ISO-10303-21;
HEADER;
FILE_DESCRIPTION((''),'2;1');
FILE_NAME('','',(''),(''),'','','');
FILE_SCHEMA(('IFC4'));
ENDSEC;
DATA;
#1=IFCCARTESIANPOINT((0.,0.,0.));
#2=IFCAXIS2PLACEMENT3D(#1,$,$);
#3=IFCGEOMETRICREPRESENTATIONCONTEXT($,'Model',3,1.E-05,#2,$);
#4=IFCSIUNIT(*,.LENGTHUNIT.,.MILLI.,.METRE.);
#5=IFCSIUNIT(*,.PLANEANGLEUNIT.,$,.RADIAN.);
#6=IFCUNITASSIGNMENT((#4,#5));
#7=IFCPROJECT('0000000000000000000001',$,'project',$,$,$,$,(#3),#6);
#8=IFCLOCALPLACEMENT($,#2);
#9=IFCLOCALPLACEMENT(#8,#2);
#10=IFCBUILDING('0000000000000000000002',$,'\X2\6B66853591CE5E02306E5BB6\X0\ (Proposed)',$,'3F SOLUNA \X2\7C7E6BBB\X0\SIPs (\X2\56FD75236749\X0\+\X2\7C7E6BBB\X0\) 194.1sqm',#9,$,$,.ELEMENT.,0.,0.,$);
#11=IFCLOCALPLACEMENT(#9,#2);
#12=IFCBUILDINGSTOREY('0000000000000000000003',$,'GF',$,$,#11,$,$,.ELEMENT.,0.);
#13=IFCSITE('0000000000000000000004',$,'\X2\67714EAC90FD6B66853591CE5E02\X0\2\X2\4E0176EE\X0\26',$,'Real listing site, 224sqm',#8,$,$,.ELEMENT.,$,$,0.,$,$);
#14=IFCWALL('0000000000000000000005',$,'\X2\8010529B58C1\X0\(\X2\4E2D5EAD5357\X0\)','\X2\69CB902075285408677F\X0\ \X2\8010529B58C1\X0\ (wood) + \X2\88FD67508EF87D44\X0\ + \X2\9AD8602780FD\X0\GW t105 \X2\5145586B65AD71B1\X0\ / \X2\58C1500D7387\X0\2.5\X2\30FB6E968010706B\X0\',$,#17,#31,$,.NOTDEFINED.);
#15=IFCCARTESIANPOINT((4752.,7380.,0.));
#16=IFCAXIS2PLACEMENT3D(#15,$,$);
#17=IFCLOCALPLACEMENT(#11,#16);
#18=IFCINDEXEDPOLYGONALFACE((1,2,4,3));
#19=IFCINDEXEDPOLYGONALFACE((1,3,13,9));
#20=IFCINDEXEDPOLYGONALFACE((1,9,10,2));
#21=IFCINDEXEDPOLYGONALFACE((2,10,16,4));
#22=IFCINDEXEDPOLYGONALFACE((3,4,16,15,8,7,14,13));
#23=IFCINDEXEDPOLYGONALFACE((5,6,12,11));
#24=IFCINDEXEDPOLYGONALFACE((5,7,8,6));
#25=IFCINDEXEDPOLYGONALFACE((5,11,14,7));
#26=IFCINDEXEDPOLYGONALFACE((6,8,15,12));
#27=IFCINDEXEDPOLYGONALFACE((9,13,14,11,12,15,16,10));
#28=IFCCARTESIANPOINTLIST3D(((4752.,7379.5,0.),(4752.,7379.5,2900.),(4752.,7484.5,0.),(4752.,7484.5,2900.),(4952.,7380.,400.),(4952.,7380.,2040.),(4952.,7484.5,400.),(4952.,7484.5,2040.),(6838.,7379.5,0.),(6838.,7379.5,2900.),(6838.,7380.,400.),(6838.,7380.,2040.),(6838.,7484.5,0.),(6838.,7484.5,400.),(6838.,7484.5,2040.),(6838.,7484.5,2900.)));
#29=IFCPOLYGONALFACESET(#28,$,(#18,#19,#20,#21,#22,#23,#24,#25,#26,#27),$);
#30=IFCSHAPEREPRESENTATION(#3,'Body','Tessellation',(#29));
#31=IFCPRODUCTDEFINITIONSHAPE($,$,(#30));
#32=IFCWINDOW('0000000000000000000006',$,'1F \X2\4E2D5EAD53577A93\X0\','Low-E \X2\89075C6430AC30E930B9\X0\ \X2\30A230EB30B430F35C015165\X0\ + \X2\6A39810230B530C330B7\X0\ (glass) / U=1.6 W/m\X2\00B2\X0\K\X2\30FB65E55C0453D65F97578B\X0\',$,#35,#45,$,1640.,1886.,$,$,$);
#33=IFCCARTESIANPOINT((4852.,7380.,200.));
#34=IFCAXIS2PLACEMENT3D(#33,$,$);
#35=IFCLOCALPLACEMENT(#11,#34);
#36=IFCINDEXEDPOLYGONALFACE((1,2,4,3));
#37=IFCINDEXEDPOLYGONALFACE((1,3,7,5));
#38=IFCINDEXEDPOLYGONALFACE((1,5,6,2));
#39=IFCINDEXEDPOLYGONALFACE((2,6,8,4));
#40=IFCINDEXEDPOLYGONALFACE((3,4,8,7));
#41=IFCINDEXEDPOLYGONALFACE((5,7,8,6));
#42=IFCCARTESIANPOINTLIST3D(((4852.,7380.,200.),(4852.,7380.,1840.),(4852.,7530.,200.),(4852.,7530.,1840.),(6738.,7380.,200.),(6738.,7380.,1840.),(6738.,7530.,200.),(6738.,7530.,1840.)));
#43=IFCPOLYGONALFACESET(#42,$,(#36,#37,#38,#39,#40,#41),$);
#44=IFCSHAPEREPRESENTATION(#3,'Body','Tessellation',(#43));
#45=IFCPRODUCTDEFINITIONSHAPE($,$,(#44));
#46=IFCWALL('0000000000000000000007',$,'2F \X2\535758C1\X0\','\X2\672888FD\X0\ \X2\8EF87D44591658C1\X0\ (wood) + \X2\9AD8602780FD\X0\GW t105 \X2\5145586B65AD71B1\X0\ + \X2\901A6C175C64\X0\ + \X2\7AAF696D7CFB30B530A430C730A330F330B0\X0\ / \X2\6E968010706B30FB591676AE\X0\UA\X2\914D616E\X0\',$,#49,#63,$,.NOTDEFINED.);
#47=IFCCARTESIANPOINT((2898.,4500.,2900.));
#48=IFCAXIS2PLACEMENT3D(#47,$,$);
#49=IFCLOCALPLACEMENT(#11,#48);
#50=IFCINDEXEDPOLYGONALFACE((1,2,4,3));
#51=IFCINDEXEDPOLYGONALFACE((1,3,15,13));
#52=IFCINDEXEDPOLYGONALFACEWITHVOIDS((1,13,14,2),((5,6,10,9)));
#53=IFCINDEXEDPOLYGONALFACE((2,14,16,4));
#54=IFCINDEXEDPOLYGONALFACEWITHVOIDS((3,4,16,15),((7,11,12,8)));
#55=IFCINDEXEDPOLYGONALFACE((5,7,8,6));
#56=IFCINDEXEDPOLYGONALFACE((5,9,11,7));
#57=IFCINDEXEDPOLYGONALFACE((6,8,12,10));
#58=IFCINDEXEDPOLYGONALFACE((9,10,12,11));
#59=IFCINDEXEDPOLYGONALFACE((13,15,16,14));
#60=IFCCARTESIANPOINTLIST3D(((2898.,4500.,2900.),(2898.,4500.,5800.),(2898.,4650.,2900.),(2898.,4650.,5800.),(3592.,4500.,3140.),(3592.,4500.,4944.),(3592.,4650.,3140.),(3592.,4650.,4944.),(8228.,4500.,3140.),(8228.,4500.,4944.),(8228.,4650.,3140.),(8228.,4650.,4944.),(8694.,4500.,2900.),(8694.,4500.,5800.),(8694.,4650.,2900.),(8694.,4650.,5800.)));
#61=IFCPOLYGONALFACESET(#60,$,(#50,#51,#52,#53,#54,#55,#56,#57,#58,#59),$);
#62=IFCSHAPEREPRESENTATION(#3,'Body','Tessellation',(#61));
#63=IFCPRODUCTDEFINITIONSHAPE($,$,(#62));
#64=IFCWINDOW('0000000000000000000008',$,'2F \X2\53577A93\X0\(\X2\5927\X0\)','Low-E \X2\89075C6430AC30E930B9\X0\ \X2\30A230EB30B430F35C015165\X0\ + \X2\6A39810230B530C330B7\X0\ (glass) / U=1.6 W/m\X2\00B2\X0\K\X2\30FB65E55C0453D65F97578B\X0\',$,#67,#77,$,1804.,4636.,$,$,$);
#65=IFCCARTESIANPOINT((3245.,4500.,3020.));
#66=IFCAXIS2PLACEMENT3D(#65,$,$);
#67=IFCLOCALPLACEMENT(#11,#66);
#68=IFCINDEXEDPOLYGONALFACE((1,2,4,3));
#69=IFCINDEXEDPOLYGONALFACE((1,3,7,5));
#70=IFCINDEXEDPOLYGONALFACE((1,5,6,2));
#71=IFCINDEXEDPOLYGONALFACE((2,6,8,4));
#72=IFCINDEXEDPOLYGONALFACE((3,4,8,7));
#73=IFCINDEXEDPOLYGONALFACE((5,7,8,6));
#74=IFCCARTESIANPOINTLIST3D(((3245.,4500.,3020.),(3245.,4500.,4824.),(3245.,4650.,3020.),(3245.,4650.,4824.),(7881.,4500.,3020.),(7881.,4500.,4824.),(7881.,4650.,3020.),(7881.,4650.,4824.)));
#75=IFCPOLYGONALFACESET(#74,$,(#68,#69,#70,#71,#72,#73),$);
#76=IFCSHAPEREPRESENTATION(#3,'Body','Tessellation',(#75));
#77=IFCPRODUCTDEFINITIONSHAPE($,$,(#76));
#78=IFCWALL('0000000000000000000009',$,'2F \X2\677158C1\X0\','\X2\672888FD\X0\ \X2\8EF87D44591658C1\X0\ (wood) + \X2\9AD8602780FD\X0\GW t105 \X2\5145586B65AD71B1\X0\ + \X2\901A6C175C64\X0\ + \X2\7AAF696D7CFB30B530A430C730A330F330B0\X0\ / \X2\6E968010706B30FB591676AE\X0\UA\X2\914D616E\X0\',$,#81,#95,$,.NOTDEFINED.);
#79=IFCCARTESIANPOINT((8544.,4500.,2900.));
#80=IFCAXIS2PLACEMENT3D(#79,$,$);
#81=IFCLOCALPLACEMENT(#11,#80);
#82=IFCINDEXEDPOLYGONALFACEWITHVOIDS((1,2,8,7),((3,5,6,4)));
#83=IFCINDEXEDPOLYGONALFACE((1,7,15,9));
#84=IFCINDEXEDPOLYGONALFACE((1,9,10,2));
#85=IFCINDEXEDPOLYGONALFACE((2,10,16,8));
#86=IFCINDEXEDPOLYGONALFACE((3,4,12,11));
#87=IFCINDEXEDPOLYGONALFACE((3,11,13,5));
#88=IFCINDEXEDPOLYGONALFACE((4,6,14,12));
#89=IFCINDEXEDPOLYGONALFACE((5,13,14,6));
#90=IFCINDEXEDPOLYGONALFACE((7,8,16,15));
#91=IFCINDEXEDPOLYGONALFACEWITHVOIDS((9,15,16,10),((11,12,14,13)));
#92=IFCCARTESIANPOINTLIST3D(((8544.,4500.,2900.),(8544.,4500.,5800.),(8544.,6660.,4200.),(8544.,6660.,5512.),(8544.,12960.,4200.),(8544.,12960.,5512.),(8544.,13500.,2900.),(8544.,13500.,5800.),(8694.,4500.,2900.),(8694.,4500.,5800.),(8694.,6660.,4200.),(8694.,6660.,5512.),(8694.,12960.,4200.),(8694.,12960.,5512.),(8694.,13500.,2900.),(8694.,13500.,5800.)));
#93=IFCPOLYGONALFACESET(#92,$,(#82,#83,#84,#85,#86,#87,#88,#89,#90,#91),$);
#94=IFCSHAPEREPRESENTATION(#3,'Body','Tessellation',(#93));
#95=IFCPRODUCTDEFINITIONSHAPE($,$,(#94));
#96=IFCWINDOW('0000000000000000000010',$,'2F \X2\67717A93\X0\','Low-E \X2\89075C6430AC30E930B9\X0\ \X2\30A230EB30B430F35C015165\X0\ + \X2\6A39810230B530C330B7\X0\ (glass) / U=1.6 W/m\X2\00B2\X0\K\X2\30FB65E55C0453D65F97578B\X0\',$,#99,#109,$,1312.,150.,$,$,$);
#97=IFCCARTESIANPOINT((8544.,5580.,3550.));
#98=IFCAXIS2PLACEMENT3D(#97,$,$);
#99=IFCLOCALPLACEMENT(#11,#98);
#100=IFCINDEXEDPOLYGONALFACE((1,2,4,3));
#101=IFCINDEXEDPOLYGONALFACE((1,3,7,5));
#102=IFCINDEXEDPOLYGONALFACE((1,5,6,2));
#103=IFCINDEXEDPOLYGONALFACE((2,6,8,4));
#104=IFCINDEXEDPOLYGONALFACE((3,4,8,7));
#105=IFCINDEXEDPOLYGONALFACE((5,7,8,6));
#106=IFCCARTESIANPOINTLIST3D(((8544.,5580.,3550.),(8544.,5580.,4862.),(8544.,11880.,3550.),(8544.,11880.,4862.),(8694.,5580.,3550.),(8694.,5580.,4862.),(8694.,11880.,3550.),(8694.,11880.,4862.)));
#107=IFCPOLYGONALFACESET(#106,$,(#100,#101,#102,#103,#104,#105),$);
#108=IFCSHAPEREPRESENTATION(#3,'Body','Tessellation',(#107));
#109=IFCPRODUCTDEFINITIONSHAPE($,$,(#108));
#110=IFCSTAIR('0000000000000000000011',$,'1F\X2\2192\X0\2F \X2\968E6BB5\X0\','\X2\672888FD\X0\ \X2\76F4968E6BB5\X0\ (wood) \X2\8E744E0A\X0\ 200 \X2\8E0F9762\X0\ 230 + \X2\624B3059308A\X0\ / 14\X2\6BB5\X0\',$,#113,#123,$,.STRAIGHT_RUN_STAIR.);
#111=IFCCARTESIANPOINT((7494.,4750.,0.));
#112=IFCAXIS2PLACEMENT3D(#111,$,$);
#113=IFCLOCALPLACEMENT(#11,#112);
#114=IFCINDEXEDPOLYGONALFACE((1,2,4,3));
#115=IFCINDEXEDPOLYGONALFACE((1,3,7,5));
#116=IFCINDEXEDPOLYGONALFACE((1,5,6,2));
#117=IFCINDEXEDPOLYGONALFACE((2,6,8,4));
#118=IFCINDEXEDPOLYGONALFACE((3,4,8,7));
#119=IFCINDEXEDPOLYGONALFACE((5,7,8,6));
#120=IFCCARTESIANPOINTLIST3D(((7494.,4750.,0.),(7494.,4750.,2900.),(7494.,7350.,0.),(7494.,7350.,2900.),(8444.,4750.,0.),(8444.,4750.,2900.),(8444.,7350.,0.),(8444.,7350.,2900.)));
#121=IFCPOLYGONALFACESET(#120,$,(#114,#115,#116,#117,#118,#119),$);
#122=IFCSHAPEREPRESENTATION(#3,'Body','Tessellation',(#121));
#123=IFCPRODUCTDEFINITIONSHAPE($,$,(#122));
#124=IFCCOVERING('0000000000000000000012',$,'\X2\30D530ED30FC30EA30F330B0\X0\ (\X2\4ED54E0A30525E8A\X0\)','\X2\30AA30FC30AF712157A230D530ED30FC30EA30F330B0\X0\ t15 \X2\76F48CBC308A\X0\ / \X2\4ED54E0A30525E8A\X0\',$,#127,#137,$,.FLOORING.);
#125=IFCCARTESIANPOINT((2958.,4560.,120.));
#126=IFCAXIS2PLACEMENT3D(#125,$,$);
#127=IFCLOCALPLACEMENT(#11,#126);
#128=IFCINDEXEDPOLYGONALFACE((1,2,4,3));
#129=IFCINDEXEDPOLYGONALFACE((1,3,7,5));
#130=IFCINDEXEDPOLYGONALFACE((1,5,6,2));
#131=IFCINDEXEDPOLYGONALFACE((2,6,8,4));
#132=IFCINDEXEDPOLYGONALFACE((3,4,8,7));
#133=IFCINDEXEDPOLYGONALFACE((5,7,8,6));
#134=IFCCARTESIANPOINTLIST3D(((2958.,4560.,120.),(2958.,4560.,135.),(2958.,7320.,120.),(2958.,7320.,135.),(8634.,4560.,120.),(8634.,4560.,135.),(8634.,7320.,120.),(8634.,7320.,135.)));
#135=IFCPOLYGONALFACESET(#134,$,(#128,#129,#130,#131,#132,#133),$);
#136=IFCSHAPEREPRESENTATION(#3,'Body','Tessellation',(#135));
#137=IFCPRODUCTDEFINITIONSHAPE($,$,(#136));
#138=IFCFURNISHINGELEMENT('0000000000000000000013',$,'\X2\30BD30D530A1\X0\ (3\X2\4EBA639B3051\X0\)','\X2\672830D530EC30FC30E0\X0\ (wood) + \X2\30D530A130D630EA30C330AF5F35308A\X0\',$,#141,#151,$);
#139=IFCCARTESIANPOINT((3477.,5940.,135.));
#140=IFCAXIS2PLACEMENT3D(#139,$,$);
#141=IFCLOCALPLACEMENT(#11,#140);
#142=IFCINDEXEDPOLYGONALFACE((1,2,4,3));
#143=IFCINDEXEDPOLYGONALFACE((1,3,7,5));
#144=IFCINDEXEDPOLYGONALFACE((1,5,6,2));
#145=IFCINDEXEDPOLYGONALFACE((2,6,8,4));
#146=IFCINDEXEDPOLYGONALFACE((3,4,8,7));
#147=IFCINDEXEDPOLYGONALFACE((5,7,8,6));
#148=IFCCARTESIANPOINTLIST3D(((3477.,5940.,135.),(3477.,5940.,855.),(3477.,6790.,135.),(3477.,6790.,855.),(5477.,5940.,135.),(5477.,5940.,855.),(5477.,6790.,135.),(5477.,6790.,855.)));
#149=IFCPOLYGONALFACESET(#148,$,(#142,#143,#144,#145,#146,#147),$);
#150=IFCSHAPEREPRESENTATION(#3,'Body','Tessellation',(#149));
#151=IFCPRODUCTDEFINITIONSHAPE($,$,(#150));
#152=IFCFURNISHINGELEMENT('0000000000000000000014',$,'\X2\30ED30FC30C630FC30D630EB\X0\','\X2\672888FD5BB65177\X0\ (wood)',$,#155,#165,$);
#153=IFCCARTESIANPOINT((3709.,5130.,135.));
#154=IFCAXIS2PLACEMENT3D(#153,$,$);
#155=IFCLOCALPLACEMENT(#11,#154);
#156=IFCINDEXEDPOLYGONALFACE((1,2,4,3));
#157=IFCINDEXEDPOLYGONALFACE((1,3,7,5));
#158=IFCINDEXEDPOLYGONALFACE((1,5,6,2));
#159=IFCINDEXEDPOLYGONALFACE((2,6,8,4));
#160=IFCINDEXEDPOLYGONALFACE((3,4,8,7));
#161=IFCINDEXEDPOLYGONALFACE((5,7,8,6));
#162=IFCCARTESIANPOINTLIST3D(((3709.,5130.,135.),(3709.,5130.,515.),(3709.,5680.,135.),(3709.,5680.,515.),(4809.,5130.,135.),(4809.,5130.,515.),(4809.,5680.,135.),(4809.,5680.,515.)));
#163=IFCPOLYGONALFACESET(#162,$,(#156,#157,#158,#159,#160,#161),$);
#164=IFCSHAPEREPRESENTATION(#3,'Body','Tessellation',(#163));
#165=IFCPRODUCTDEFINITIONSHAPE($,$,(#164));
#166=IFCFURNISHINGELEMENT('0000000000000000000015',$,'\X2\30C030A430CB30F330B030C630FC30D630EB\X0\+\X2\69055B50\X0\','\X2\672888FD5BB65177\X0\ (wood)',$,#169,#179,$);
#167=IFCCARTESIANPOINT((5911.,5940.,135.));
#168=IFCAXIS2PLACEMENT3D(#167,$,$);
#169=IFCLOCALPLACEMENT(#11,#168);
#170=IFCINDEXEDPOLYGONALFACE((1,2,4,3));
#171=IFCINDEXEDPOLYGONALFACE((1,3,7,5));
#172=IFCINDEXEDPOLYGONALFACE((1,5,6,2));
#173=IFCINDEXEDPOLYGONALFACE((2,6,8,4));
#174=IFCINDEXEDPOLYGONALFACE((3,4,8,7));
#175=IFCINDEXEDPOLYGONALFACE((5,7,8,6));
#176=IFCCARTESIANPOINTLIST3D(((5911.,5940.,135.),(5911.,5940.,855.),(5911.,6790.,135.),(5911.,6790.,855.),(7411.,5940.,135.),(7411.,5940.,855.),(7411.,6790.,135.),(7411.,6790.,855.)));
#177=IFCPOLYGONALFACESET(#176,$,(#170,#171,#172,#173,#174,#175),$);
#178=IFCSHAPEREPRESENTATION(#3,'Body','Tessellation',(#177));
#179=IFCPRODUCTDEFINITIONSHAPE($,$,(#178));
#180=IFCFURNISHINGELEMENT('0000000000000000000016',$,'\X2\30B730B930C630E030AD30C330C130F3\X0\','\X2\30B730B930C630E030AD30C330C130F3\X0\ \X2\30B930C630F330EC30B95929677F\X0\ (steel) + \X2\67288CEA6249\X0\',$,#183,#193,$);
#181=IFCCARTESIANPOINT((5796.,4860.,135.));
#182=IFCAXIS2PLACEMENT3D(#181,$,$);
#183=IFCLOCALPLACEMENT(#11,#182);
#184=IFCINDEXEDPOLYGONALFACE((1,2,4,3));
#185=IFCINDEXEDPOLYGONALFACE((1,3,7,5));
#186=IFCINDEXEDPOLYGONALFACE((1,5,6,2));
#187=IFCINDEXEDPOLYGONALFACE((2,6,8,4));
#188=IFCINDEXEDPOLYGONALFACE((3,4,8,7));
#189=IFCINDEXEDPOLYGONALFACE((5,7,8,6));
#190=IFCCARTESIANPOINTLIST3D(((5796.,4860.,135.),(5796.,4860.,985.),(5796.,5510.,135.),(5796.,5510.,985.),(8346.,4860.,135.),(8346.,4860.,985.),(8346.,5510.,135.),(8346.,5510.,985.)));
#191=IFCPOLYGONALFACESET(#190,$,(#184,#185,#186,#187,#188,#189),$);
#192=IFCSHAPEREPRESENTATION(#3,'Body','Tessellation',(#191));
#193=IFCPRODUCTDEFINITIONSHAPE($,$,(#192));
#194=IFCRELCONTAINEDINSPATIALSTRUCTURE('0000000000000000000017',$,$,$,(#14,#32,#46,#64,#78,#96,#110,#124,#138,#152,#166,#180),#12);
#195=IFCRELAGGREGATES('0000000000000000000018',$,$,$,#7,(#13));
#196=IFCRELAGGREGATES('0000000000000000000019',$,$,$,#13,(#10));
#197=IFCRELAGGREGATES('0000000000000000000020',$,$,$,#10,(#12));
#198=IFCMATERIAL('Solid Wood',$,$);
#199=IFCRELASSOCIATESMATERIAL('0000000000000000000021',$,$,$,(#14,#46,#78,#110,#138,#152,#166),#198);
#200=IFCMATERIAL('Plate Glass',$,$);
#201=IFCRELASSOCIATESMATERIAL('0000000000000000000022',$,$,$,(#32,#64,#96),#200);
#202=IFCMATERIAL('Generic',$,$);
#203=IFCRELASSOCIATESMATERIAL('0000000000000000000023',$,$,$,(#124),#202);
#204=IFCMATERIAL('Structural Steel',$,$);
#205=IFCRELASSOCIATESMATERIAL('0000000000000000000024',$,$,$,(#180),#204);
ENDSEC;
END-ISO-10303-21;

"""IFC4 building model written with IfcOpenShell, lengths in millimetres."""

from ifc_helpers import new_model, si_unit, frame, frame_2d, origin, place, context, project, spatial, rectangle, extrude, material, element, fill, save


model = new_model("IFC4")

# Units and contexts
model_context = context("Model", 3, precision=1e-05, world=origin())
ifc_project = project(units=[si_unit("LENGTHUNIT", "METRE", prefix="MILLI"), si_unit("PLANEANGLEUNIT", "RADIAN")], contexts=[model_context])

# Site, building, storey
site_placement = place(None, origin())
site = spatial("IfcSite", under=ifc_project, at=site_placement, Name="東京都武蔵野市2丁目26", ObjectType="Real listing site, 224sqm", CompositionType="ELEMENT", RefElevation=0.0)
building_placement = place(site_placement, origin())
building = spatial("IfcBuilding", under=site, at=building_placement, Name="武蔵野市の家 (Proposed)", ObjectType="3F SOLUNA 籾殻SIPs (国産杉+籾殻) 194.1sqm", CompositionType="ELEMENT", ElevationOfRefHeight=0.0, ElevationOfTerrain=0.0)
storey_placement = place(building_placement, origin())
storey = spatial("IfcBuildingStorey", under=building, at=storey_placement, Name="GF", CompositionType="ELEMENT", Elevation=0.0)

# Shared definitions
ifc_material_1 = material(Name="Solid Wood")

# Shared definitions
ifc_material_2 = material(Name="Plate Glass")

# Wall, opening, window
wall_1_placement = place(storey_placement, frame((4752.0, 7380.0, 0.0)))
wall_1 = element("IfcWall", 1, at=wall_1_placement, inside=storey, material=ifc_material_1, Name="耐力壁(中庭南)", Description="構造用合板 耐力壁 (wood) + 製材軸組 + 高性能GW t105 充填断熱 / 壁倍率2.5・準耐火", PredefinedType="NOTDEFINED", context=model_context, shape_type="SweptSolid", body=[
    extrude(rectangle(XDim=2086.0, YDim=105.0, at=frame_2d((1043.0, 52.0))), frame((4752.0, 7380.0, 0.0)), (0.0, 0.0, 1.0), 2900.0),
])
opening_1_placement = place(storey_placement, frame((4852.0, 7380.0, 200.0)))
opening_1 = element("IfcOpeningElement", 2, at=opening_1_placement, cuts=wall_1, PredefinedType="NOTDEFINED", context=model_context, shape_type="SweptSolid", body=[
    extrude(rectangle(XDim=1886.0, YDim=150.0, at=frame_2d((943.0, 75.0))), frame((4852.0, 7380.0, 200.0)), (0.0, 0.0, 1.0), 1640.0),
])
window_1_placement = place(storey_placement, frame((4852.0, 7380.0, 200.0)))
window_1 = element("IfcWindow", 3, at=window_1_placement, inside=storey, material=ifc_material_2, Name="1F 中庭南窓", Description="Low-E 複層ガラス アルゴン封入 + 樹脂サッシ (glass) / U=1.6 W/m²K・日射取得型", OverallHeight=1640.0, OverallWidth=1886.0, context=model_context, shape_type="SweptSolid", body=[
    extrude(rectangle(XDim=1886.0, YDim=150.0, at=frame_2d((943.0, 75.0))), frame((4852.0, 7380.0, 200.0)), (0.0, 0.0, 1.0), 1640.0),
])
fill(opening_1, window_1)

# Walls, openings, windows
wall_2_placement = place(storey_placement, frame((2898.0, 4500.0, 2900.0)))
wall_2 = element("IfcWall", 4, at=wall_2_placement, inside=storey, material=ifc_material_1, Name="2F 南壁", Description="木製 軸組外壁 (wood) + 高性能GW t105 充填断熱 + 通気層 + 窯業系サイディング / 準耐火・外皮UA配慮", PredefinedType="NOTDEFINED", context=model_context, shape_type="SweptSolid", body=[
    extrude(rectangle(XDim=5796.0, YDim=150.0, at=frame_2d((2898.0, 75.0))), frame((2898.0, 4500.0, 2900.0)), (0.0, 0.0, 1.0), 2900.0),
])
opening_2_placement = place(storey_placement, frame((3245.0, 4500.0, 3020.0)))
opening_2 = element("IfcOpeningElement", 5, at=opening_2_placement, cuts=wall_2, PredefinedType="NOTDEFINED", context=model_context, shape_type="SweptSolid", body=[
    extrude(rectangle(XDim=4636.0, YDim=150.0, at=frame_2d((2318.0, 75.0))), frame((3245.0, 4500.0, 3020.0)), (0.0, 0.0, 1.0), 1804.0),
])
window_2_placement = place(storey_placement, frame((3245.0, 4500.0, 3020.0)))
window_2 = element("IfcWindow", 6, at=window_2_placement, inside=storey, material=ifc_material_2, Name="2F 南窓(大)", Description="Low-E 複層ガラス アルゴン封入 + 樹脂サッシ (glass) / U=1.6 W/m²K・日射取得型", OverallHeight=1804.0, OverallWidth=4636.0, context=model_context, shape_type="SweptSolid", body=[
    extrude(rectangle(XDim=4636.0, YDim=150.0, at=frame_2d((2318.0, 75.0))), frame((3245.0, 4500.0, 3020.0)), (0.0, 0.0, 1.0), 1804.0),
])
fill(opening_2, window_2)
wall_3_placement = place(storey_placement, frame((8544.0, 4500.0, 2900.0)))
wall_3 = element("IfcWall", 7, at=wall_3_placement, inside=storey, material=ifc_material_1, Name="2F 東壁", Description="木製 軸組外壁 (wood) + 高性能GW t105 充填断熱 + 通気層 + 窯業系サイディング / 準耐火・外皮UA配慮", PredefinedType="NOTDEFINED", context=model_context, shape_type="SweptSolid", body=[
    extrude(rectangle(XDim=150.0, YDim=9000.0, at=frame_2d((75.0, 4500.0))), frame((8544.0, 4500.0, 2900.0)), (0.0, 0.0, 1.0), 2900.0),
])
opening_3_placement = place(storey_placement, frame((8544.0, 5580.0, 3550.0)))
opening_3 = element("IfcOpeningElement", 8, at=opening_3_placement, cuts=wall_3, PredefinedType="NOTDEFINED", context=model_context, shape_type="SweptSolid", body=[
    extrude(rectangle(XDim=150.0, YDim=6300.0, at=frame_2d((75.0, 3150.0))), frame((8544.0, 5580.0, 3550.0)), (0.0, 0.0, 1.0), 1312.0),
])
window_3_placement = place(storey_placement, frame((8544.0, 5580.0, 3550.0)))
window_3 = element("IfcWindow", 9, at=window_3_placement, inside=storey, material=ifc_material_2, Name="2F 東窓", Description="Low-E 複層ガラス アルゴン封入 + 樹脂サッシ (glass) / U=1.6 W/m²K・日射取得型", OverallHeight=1312.0, OverallWidth=150.0, context=model_context, shape_type="SweptSolid", body=[
    extrude(rectangle(XDim=150.0, YDim=6300.0, at=frame_2d((75.0, 3150.0))), frame((8544.0, 5580.0, 3550.0)), (0.0, 0.0, 1.0), 1312.0),
])
fill(opening_3, window_3)

# Stair
stair_placement = place(storey_placement, frame((7494.0, 4750.0, 0.0)))
element("IfcStair", 10, at=stair_placement, inside=storey, material=ifc_material_1, Name="1F→2F 階段", Description="木製 直階段 (wood) 蹴上 200 踏面 230 + 手すり / 14段", PredefinedType="STRAIGHT_RUN_STAIR", context=model_context, shape_type="SweptSolid", body=[
    extrude(rectangle(XDim=950.0, YDim=2600.0, at=frame_2d((475.0, 1300.0))), frame((7494.0, 4750.0, 0.0)), (0.0, 0.0, 1.0), 2900.0),
])

# Covering
ifc_material_3 = material(Name="Generic")
covering_placement = place(storey_placement, frame((2958.0, 4560.0, 120.0)))
element("IfcCovering", 11, at=covering_placement, inside=storey, material=ifc_material_3, Name="フローリング (仕上げ床)", Description="オーク無垢フローリング t15 直貼り / 仕上げ床", PredefinedType="FLOORING", context=model_context, shape_type="SweptSolid", body=[
    extrude(rectangle(XDim=5676.0, YDim=2760.0, at=frame_2d((2838.0, 1380.0))), frame((2958.0, 4560.0, 120.0)), (0.0, 0.0, 1.0), 15.0),
])

# Furnishing elements
furnishing_1_placement = place(storey_placement, frame((3477.0, 5940.0, 135.0)))
element("IfcFurnishingElement", 12, at=furnishing_1_placement, inside=storey, material=ifc_material_1, Name="ソファ (3人掛け)", Description="木フレーム (wood) + ファブリック張り", context=model_context, shape_type="SweptSolid", body=[
    extrude(rectangle(XDim=2000.0, YDim=850.0, at=frame_2d((1000.0, 425.0))), frame((3477.0, 5940.0, 135.0)), (0.0, 0.0, 1.0), 720.0),
])
furnishing_2_placement = place(storey_placement, frame((3709.0, 5130.0, 135.0)))
element("IfcFurnishingElement", 13, at=furnishing_2_placement, inside=storey, material=ifc_material_1, Name="ローテーブル", Description="木製家具 (wood)", context=model_context, shape_type="SweptSolid", body=[
    extrude(rectangle(XDim=1100.0, YDim=550.0, at=frame_2d((550.0, 275.0))), frame((3709.0, 5130.0, 135.0)), (0.0, 0.0, 1.0), 380.0),
])
furnishing_3_placement = place(storey_placement, frame((5911.0, 5940.0, 135.0)))
element("IfcFurnishingElement", 14, at=furnishing_3_placement, inside=storey, material=ifc_material_1, Name="ダイニングテーブル+椅子", Description="木製家具 (wood)", context=model_context, shape_type="SweptSolid", body=[
    extrude(rectangle(XDim=1500.0, YDim=850.0, at=frame_2d((750.0, 425.0))), frame((5911.0, 5940.0, 135.0)), (0.0, 0.0, 1.0), 720.0),
])
ifc_material_4 = material(Name="Structural Steel")
furnishing_4_placement = place(storey_placement, frame((5796.0, 4860.0, 135.0)))
element("IfcFurnishingElement", 15, at=furnishing_4_placement, inside=storey, material=ifc_material_4, Name="システムキッチン", Description="システムキッチン ステンレス天板 (steel) + 木質扉", context=model_context, shape_type="SweptSolid", body=[
    extrude(rectangle(XDim=2550.0, YDim=650.0, at=frame_2d((1275.0, 325.0))), frame((5796.0, 4860.0, 135.0)), (0.0, 0.0, 1.0), 850.0),
])

save(model, "model.ifc")
